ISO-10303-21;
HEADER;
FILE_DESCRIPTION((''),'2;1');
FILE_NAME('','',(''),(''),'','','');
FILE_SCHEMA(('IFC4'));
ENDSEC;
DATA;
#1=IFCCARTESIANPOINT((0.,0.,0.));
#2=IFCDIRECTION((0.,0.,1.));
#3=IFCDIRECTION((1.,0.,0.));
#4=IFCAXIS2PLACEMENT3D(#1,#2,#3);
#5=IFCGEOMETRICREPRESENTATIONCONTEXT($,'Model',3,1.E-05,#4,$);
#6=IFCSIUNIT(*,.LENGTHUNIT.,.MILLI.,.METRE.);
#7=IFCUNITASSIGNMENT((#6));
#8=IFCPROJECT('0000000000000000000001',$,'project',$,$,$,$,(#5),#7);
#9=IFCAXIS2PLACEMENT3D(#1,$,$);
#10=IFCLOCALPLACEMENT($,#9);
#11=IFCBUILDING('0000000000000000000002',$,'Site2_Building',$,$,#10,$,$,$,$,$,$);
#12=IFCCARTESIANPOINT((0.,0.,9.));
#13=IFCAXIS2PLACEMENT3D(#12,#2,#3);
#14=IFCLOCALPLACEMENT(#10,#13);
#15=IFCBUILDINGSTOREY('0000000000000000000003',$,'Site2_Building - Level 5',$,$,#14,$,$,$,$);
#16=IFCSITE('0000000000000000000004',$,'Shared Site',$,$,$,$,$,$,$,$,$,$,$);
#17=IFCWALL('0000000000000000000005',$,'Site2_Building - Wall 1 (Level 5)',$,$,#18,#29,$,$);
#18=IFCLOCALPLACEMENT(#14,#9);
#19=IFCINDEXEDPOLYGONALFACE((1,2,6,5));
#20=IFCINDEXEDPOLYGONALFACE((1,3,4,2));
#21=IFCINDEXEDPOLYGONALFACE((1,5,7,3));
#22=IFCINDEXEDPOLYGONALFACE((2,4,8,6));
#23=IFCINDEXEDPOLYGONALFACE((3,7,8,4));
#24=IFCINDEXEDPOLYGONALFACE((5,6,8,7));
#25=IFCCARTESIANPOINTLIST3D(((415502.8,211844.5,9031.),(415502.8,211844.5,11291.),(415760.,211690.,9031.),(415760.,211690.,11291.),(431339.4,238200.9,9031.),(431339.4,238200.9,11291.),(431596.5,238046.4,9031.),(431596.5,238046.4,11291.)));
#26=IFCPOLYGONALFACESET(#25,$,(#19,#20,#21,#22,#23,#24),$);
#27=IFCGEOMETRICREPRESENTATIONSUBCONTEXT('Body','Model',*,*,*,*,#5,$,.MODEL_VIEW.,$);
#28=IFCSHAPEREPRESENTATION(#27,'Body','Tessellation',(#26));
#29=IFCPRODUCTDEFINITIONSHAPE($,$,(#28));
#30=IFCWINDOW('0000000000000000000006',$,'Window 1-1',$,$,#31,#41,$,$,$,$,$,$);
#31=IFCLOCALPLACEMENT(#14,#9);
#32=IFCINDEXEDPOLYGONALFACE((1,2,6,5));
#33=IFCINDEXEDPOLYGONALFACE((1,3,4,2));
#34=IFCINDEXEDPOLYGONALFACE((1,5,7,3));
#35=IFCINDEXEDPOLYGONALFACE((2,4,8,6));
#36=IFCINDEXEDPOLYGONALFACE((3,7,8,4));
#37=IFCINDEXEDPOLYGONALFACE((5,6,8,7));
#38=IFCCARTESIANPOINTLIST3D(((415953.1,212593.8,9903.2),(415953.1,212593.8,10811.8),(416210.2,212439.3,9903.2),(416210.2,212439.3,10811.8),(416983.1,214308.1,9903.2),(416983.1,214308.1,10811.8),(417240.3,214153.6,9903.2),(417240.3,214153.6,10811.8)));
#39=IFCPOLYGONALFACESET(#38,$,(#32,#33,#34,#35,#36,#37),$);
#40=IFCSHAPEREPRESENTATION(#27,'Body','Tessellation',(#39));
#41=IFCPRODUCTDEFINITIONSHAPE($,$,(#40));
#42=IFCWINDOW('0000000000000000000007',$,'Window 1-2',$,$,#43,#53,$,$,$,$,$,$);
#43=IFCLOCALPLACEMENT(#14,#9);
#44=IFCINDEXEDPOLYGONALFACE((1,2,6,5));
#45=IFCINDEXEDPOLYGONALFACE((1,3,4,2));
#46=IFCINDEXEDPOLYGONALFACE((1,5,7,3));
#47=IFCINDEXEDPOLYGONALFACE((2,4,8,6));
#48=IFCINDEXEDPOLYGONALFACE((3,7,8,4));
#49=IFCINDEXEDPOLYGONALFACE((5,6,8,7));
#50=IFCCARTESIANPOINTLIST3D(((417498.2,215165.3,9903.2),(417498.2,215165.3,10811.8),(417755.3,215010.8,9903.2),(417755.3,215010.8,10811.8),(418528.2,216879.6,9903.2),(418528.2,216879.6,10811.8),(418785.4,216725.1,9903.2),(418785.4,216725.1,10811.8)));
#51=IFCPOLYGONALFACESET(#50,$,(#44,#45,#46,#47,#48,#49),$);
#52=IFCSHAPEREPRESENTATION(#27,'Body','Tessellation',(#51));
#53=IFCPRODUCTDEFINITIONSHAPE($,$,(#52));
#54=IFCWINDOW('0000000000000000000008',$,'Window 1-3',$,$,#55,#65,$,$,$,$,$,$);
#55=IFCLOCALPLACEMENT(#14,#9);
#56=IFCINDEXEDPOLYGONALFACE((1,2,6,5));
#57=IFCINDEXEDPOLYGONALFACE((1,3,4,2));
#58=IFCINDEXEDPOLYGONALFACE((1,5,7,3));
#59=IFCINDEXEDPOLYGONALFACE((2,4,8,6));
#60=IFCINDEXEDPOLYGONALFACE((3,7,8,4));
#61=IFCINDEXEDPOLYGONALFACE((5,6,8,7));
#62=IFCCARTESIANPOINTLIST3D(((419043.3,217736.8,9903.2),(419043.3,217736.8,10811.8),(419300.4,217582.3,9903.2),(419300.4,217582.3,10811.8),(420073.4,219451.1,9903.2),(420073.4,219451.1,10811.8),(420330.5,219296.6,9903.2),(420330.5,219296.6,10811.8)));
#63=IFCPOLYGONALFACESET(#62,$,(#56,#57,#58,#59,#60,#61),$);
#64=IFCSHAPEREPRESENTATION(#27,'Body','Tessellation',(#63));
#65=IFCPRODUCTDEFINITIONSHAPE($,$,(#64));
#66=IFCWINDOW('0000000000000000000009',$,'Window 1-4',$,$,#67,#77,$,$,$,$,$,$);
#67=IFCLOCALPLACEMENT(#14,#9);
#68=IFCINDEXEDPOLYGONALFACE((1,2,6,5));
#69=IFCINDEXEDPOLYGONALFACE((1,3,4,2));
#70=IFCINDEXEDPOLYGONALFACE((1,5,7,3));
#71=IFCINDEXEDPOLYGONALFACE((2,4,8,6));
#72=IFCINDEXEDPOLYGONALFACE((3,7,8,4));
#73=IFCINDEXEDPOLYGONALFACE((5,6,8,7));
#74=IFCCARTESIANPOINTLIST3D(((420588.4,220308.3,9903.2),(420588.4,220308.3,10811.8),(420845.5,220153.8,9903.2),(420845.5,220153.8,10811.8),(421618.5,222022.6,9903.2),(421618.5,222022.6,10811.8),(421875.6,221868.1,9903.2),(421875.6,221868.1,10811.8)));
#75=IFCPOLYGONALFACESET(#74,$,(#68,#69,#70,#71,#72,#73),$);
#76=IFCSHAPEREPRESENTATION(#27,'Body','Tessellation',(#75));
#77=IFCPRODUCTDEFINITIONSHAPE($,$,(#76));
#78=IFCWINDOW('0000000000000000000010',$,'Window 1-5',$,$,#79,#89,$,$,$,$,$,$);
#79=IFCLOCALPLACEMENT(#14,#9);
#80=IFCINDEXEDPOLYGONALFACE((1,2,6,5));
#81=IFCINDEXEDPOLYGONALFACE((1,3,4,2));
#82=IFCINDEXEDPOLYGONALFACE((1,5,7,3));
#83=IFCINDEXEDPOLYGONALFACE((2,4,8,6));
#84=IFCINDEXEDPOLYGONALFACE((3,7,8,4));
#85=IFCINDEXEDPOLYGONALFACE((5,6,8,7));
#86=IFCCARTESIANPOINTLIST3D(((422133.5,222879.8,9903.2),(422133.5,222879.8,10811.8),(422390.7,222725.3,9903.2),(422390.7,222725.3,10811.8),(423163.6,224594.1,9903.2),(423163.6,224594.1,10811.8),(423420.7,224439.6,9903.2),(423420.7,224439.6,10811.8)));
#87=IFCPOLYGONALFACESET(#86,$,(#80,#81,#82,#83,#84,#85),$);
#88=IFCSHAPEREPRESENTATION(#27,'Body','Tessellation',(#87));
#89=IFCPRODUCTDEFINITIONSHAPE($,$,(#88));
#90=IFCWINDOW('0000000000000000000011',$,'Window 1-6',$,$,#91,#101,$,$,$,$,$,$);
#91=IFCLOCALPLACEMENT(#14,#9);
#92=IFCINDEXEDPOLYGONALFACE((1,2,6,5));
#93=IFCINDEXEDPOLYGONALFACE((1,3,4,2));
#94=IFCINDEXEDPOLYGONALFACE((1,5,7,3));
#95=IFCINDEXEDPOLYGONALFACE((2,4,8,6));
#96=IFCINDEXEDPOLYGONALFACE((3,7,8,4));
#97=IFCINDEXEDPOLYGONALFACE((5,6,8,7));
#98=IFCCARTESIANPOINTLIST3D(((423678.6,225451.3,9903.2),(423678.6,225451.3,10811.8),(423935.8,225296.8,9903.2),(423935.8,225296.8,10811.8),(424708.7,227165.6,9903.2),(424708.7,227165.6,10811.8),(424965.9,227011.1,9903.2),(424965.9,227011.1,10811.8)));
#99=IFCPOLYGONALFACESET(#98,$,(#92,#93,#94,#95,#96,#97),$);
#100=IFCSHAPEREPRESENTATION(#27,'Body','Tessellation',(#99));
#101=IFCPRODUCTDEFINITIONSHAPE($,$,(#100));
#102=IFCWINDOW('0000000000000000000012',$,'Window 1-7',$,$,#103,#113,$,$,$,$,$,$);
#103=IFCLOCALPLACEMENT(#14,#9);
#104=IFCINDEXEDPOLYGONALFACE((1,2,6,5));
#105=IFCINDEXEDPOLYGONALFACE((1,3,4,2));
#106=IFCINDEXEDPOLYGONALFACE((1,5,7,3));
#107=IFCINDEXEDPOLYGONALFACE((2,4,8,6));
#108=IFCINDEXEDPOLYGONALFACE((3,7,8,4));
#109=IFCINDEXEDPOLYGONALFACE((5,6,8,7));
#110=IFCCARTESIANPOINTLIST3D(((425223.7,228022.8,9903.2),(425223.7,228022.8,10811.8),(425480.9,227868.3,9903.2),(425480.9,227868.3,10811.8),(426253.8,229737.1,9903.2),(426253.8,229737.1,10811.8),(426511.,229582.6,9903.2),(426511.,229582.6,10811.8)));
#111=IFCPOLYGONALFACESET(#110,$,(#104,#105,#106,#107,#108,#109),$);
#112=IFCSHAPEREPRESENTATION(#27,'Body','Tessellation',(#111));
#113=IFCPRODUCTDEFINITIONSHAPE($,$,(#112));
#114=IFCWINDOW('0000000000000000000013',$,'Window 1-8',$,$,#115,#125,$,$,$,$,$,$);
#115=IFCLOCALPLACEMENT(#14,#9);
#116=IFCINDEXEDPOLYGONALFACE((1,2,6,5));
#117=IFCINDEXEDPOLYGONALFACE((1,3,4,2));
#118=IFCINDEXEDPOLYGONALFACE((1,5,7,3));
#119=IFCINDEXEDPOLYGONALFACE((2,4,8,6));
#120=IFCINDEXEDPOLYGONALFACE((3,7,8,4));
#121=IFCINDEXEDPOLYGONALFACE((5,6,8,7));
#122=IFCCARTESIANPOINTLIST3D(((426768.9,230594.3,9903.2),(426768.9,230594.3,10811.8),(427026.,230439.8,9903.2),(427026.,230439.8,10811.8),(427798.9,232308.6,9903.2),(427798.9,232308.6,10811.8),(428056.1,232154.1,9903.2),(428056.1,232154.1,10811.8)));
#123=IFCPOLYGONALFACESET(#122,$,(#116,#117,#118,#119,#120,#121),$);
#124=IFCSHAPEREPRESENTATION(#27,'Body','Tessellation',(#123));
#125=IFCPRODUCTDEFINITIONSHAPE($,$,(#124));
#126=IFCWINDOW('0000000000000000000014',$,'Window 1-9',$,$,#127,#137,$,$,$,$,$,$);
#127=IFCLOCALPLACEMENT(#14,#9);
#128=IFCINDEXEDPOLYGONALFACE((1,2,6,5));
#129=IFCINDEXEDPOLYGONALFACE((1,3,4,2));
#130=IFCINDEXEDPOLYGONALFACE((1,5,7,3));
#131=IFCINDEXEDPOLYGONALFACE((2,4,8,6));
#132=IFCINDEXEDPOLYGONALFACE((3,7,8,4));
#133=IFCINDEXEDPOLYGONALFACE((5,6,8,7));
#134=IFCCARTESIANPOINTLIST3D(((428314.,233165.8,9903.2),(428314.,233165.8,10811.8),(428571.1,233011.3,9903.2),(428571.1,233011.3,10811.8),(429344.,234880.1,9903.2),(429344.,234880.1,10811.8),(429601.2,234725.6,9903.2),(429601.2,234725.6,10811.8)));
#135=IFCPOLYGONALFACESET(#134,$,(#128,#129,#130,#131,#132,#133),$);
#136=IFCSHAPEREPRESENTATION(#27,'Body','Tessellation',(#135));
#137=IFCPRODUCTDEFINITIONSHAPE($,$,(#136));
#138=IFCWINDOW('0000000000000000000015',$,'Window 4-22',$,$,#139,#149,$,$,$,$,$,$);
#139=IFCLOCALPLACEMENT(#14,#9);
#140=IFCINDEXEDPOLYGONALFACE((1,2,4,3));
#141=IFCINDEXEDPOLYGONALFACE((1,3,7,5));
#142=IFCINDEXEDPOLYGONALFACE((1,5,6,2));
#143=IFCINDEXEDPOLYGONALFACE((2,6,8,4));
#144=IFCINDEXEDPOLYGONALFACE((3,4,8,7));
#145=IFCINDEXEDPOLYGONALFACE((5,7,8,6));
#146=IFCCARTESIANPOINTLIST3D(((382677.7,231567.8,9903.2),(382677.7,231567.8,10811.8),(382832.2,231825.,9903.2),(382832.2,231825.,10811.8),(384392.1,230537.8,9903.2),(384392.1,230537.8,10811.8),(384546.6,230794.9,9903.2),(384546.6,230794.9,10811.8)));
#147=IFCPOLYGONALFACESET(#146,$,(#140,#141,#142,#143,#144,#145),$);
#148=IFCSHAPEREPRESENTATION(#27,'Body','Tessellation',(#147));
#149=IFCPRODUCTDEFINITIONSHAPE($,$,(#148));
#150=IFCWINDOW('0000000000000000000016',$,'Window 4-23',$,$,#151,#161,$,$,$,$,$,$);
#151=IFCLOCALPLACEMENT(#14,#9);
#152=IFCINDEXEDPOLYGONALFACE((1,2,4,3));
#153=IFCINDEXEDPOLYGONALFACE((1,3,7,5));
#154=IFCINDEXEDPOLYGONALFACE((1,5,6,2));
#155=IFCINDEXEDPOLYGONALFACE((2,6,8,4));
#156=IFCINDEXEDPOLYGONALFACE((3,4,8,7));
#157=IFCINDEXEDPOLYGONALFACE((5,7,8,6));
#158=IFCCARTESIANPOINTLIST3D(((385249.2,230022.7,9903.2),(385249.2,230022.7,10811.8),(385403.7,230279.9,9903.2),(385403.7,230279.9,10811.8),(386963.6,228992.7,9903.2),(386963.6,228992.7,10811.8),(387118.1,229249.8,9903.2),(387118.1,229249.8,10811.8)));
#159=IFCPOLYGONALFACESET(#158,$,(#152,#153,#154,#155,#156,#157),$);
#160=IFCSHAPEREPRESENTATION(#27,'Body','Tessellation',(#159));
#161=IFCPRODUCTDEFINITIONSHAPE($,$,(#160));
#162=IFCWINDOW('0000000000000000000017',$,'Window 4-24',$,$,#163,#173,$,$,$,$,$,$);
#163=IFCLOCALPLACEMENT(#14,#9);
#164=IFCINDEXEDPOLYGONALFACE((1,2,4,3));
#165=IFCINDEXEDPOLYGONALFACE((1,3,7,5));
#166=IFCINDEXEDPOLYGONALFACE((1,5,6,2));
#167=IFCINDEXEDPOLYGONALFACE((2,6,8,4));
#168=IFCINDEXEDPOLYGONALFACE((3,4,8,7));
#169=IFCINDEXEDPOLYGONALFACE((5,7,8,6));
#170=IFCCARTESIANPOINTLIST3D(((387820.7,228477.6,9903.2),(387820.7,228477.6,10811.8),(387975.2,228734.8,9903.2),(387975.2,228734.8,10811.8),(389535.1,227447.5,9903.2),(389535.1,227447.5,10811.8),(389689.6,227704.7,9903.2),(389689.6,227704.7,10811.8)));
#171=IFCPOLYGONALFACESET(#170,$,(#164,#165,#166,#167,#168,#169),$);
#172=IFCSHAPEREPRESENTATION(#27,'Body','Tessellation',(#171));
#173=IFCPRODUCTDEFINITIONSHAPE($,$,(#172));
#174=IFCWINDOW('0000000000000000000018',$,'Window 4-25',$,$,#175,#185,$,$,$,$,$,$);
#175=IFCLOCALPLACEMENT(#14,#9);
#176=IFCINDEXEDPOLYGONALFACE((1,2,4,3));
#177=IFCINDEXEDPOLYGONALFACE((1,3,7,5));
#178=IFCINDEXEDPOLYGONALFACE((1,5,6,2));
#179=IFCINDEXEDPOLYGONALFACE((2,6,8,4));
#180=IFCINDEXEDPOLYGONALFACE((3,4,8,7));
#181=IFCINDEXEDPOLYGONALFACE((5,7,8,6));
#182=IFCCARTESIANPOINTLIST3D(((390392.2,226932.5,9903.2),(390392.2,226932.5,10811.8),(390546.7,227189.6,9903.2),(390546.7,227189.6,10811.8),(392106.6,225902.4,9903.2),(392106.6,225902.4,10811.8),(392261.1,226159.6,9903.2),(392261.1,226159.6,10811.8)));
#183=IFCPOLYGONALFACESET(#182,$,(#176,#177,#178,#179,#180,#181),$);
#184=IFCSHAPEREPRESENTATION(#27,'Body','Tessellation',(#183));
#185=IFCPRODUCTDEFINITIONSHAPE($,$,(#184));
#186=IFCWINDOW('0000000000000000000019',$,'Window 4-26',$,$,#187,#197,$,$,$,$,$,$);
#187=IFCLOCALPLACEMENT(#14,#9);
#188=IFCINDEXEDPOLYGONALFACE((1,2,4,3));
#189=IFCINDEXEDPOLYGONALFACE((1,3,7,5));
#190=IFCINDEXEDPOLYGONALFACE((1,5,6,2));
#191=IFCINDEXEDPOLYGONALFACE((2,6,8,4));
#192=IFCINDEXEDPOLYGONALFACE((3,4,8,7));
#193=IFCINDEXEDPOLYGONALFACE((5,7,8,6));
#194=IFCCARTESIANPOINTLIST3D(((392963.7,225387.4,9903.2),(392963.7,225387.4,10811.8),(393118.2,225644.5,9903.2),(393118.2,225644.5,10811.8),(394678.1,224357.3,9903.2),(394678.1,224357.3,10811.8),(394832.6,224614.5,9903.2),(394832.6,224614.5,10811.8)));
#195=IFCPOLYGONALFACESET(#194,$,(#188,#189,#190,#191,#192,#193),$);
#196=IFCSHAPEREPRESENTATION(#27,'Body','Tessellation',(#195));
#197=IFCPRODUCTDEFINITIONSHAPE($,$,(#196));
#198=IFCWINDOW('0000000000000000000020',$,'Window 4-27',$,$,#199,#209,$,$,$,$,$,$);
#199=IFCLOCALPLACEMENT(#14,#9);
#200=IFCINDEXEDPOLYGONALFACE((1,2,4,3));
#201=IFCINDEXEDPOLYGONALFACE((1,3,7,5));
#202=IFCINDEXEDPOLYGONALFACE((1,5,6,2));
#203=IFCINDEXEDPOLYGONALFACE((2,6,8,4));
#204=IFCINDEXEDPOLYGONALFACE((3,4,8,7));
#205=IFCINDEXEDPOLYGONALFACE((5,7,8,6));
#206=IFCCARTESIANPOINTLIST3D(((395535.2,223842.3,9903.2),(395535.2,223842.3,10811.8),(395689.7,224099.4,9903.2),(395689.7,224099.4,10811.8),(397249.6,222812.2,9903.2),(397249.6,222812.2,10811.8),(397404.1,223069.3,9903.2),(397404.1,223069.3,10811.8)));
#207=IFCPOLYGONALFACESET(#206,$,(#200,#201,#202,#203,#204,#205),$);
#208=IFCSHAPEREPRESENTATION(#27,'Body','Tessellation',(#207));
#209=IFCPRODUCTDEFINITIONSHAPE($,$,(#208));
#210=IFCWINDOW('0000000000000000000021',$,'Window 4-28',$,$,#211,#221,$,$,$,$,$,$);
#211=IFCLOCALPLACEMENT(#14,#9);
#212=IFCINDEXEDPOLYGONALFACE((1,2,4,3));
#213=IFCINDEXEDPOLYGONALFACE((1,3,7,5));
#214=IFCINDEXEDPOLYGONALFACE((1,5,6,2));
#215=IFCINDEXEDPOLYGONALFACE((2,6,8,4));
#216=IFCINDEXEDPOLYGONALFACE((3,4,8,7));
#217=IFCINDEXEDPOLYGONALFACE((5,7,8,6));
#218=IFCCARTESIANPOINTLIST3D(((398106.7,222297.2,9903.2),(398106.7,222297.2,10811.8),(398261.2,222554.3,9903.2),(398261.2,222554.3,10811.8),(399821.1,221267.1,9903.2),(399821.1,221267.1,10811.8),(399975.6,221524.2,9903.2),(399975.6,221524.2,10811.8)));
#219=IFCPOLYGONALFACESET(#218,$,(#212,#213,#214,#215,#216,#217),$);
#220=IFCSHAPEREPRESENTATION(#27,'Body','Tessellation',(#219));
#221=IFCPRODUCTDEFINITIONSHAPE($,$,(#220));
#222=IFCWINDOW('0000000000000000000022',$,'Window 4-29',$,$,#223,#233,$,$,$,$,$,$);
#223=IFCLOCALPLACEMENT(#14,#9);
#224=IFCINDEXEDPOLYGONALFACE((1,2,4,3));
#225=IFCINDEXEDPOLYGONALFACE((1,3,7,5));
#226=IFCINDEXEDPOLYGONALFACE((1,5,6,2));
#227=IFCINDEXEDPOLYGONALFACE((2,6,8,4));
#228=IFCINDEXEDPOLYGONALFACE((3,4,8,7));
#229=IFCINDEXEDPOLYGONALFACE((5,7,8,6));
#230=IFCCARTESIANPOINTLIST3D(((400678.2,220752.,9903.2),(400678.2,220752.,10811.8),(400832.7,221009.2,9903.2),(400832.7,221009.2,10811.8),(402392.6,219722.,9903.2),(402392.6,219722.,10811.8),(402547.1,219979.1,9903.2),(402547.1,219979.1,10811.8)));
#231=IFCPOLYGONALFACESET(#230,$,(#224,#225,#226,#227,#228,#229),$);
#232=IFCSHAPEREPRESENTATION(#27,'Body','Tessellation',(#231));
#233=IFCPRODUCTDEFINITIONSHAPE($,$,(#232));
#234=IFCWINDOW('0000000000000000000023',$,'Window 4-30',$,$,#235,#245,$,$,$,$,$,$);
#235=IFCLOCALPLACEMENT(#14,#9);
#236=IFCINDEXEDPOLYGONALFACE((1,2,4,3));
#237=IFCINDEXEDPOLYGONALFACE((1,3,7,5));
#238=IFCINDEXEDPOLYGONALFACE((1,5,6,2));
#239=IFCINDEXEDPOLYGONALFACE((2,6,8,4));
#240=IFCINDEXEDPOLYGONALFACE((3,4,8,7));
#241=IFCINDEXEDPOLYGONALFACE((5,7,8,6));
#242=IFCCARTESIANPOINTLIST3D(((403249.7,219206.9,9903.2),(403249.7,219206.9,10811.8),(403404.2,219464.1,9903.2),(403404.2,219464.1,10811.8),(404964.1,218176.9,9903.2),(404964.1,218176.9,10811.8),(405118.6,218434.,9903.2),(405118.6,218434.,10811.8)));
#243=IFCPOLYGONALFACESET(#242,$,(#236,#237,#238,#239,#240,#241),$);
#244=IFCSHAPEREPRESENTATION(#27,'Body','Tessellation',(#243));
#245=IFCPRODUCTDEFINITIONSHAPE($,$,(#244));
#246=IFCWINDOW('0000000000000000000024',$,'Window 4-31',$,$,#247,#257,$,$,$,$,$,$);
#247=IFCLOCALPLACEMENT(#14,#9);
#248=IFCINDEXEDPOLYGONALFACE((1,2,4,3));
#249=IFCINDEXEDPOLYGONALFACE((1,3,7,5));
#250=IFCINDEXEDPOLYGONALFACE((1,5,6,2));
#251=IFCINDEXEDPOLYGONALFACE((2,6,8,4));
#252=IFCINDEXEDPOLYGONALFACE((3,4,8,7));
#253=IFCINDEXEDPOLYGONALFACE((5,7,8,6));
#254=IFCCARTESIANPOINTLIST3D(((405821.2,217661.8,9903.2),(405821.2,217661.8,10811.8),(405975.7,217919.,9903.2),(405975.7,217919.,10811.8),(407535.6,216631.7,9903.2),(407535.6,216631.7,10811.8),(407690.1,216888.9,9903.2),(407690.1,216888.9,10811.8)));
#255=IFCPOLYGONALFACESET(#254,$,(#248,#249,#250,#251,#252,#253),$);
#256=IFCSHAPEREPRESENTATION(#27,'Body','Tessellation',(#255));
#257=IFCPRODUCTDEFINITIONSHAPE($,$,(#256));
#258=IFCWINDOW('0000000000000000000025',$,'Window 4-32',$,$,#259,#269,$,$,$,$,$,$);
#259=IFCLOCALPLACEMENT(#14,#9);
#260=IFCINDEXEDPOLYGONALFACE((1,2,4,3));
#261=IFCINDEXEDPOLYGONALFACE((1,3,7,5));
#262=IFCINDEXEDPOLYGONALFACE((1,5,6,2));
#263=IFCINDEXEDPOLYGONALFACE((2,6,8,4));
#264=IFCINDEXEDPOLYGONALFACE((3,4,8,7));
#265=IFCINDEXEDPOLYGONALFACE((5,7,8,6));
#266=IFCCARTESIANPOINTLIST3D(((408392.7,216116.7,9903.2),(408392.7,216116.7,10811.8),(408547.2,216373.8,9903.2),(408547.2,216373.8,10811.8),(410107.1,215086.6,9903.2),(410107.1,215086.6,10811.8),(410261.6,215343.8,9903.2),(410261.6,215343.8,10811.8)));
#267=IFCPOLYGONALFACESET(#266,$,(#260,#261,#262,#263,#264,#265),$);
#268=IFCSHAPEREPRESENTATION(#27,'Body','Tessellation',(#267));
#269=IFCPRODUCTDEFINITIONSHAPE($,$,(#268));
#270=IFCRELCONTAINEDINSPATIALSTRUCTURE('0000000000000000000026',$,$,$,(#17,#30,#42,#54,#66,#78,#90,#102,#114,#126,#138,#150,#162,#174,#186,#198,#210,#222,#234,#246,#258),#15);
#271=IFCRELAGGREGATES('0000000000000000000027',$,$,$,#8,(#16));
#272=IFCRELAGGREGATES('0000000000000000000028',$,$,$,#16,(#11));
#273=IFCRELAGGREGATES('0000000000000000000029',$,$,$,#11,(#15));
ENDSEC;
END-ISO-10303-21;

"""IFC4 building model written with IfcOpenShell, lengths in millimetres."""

from ifc_helpers import new_model, si_unit, frame, origin, origin_with_axes, place, context, subcontext, project, spatial, indexed_curve, outline, extrude, element, save


model = new_model("IFC4")

# Units and contexts
model_context = context("Model", 3, precision=1e-05, world=origin_with_axes())
body_context = subcontext(model_context, "Body", "Model", "MODEL_VIEW")
ifc_project = project(units=[si_unit("LENGTHUNIT", "METRE", prefix="MILLI")], contexts=[model_context])

# Site, building, storey
site = spatial("IfcSite", under=ifc_project, Name="Shared Site")
building_placement = place(None, origin())
building = spatial("IfcBuilding", under=site, at=building_placement, Name="Site2_Building")
storey_placement = place(building_placement, frame((0.0, 0.0, 9.0), z_axis=(0.0, 0.0, 1.0), x_axis=(1.0, 0.0, 0.0)))
storey = spatial("IfcBuildingStorey", under=building, at=storey_placement, Name="Site2_Building - Level 5")

# Wall
wall_placement = place(storey_placement, frame((415760.0, 211690.0, 9031.0), z_axis=(0.0, 0.0, 1.0), x_axis=(0.515038, 0.857167, 0.0)))
element("IfcWall", 1, at=wall_placement, inside=storey, Name="Site2_Building - Wall 1 (Level 5)", context=body_context, shape_type="SweptSolid", body=[
    extrude(outline(indexed_curve([(0.0, 0.0), (0.0, 300.0), (30748.2, 300.0), (30748.2, 0.0), (0.0, 0.0)], self_intersect=False)), origin_with_axes(), (0.0, 0.0, 1.0), 2260.0),
])

# Windows
for number, where, z_axis, x_axis, name in (
    (2, (416210.2, 212439.3, 9903.2), (0.0, 0.0, 1.0), (0.515038, 0.857167, 0.0), "Window 1-1"),
    (3, (417755.3, 215010.8, 9903.2), (0.0, 0.0, 1.0), (0.515038, 0.857167, 0.0), "Window 1-2"),
    (4, (419300.4, 217582.3, 9903.2), (0.0, 0.0, 1.0), (0.515038, 0.857167, 0.0), "Window 1-3"),
    (5, (420845.5, 220153.8, 9903.2), (0.0, 0.0, 1.0), (0.515038, 0.857167, 0.0), "Window 1-4"),
    (6, (422390.7, 222725.3, 9903.2), (0.0, 0.0, 1.0), (0.515038, 0.857167, 0.0), "Window 1-5"),
    (7, (423935.8, 225296.8, 9903.2), (0.0, 0.0, 1.0), (0.515038, 0.857167, 0.0), "Window 1-6"),
    (8, (425480.9, 227868.3, 9903.2), (0.0, 0.0, 1.0), (0.515038, 0.857167, 0.0), "Window 1-7"),
    (9, (427026.0, 230439.8, 9903.2), (0.0, 0.0, 1.0), (0.515038, 0.857167, 0.0), "Window 1-8"),
    (10, (428571.1, 233011.3, 9903.2), (0.0, 0.0, 1.0), (0.515038, 0.857167, 0.0), "Window 1-9"),
    (11, (382677.7, 231567.8, 9903.2), (0.0, 0.0, 1.0), (0.857167, -0.515038, 0.0), "Window 4-22"),
    (12, (385249.2, 230022.7, 9903.2), (0.0, 0.0, 1.0), (0.857167, -0.515038, 0.0), "Window 4-23"),
    (13, (387820.7, 228477.6, 9903.2), (0.0, 0.0, 1.0), (0.857167, -0.515038, 0.0), "Window 4-24"),
    (14, (390392.2, 226932.5, 9903.2), (0.0, 0.0, 1.0), (0.857167, -0.515038, 0.0), "Window 4-25"),
    (15, (392963.7, 225387.4, 9903.2), (0.0, 0.0, 1.0), (0.857167, -0.515038, 0.0), "Window 4-26"),
    (16, (395535.2, 223842.3, 9903.2), (0.0, 0.0, 1.0), (0.857167, -0.515038, 0.0), "Window 4-27"),
    (17, (398106.7, 222297.2, 9903.2), (0.0, 0.0, 1.0), (0.857167, -0.515038, 0.0), "Window 4-28"),
    (18, (400678.2, 220752.0, 9903.2), (0.0, 0.0, 1.0), (0.857167, -0.515038, 0.0), "Window 4-29"),
    (19, (403249.7, 219206.9, 9903.2), (0.0, 0.0, 1.0), (0.857167, -0.515038, 0.0), "Window 4-30"),
    (20, (405821.2, 217661.8, 9903.2), (0.0, 0.0, 1.0), (0.857167, -0.515038, 0.0), "Window 4-31"),
    (21, (408392.7, 216116.7, 9903.2), (0.0, 0.0, 1.0), (0.857167, -0.515038, 0.0), "Window 4-32"),
):
    element("IfcWindow", number, at=place(storey_placement, frame(where, z_axis=z_axis, x_axis=x_axis)), inside=storey, Name=name, context=body_context, shape_type="SweptSolid", body=[
        extrude(outline(indexed_curve([(0.0, 0.0), (0.0, 300.0), (2000.0, 300.0), (2000.0, 0.0), (0.0, 0.0)], self_intersect=False)), origin_with_axes(), (0.0, 0.0, 1.0), 908.6),
    ])

save(model, "model.ifc")
